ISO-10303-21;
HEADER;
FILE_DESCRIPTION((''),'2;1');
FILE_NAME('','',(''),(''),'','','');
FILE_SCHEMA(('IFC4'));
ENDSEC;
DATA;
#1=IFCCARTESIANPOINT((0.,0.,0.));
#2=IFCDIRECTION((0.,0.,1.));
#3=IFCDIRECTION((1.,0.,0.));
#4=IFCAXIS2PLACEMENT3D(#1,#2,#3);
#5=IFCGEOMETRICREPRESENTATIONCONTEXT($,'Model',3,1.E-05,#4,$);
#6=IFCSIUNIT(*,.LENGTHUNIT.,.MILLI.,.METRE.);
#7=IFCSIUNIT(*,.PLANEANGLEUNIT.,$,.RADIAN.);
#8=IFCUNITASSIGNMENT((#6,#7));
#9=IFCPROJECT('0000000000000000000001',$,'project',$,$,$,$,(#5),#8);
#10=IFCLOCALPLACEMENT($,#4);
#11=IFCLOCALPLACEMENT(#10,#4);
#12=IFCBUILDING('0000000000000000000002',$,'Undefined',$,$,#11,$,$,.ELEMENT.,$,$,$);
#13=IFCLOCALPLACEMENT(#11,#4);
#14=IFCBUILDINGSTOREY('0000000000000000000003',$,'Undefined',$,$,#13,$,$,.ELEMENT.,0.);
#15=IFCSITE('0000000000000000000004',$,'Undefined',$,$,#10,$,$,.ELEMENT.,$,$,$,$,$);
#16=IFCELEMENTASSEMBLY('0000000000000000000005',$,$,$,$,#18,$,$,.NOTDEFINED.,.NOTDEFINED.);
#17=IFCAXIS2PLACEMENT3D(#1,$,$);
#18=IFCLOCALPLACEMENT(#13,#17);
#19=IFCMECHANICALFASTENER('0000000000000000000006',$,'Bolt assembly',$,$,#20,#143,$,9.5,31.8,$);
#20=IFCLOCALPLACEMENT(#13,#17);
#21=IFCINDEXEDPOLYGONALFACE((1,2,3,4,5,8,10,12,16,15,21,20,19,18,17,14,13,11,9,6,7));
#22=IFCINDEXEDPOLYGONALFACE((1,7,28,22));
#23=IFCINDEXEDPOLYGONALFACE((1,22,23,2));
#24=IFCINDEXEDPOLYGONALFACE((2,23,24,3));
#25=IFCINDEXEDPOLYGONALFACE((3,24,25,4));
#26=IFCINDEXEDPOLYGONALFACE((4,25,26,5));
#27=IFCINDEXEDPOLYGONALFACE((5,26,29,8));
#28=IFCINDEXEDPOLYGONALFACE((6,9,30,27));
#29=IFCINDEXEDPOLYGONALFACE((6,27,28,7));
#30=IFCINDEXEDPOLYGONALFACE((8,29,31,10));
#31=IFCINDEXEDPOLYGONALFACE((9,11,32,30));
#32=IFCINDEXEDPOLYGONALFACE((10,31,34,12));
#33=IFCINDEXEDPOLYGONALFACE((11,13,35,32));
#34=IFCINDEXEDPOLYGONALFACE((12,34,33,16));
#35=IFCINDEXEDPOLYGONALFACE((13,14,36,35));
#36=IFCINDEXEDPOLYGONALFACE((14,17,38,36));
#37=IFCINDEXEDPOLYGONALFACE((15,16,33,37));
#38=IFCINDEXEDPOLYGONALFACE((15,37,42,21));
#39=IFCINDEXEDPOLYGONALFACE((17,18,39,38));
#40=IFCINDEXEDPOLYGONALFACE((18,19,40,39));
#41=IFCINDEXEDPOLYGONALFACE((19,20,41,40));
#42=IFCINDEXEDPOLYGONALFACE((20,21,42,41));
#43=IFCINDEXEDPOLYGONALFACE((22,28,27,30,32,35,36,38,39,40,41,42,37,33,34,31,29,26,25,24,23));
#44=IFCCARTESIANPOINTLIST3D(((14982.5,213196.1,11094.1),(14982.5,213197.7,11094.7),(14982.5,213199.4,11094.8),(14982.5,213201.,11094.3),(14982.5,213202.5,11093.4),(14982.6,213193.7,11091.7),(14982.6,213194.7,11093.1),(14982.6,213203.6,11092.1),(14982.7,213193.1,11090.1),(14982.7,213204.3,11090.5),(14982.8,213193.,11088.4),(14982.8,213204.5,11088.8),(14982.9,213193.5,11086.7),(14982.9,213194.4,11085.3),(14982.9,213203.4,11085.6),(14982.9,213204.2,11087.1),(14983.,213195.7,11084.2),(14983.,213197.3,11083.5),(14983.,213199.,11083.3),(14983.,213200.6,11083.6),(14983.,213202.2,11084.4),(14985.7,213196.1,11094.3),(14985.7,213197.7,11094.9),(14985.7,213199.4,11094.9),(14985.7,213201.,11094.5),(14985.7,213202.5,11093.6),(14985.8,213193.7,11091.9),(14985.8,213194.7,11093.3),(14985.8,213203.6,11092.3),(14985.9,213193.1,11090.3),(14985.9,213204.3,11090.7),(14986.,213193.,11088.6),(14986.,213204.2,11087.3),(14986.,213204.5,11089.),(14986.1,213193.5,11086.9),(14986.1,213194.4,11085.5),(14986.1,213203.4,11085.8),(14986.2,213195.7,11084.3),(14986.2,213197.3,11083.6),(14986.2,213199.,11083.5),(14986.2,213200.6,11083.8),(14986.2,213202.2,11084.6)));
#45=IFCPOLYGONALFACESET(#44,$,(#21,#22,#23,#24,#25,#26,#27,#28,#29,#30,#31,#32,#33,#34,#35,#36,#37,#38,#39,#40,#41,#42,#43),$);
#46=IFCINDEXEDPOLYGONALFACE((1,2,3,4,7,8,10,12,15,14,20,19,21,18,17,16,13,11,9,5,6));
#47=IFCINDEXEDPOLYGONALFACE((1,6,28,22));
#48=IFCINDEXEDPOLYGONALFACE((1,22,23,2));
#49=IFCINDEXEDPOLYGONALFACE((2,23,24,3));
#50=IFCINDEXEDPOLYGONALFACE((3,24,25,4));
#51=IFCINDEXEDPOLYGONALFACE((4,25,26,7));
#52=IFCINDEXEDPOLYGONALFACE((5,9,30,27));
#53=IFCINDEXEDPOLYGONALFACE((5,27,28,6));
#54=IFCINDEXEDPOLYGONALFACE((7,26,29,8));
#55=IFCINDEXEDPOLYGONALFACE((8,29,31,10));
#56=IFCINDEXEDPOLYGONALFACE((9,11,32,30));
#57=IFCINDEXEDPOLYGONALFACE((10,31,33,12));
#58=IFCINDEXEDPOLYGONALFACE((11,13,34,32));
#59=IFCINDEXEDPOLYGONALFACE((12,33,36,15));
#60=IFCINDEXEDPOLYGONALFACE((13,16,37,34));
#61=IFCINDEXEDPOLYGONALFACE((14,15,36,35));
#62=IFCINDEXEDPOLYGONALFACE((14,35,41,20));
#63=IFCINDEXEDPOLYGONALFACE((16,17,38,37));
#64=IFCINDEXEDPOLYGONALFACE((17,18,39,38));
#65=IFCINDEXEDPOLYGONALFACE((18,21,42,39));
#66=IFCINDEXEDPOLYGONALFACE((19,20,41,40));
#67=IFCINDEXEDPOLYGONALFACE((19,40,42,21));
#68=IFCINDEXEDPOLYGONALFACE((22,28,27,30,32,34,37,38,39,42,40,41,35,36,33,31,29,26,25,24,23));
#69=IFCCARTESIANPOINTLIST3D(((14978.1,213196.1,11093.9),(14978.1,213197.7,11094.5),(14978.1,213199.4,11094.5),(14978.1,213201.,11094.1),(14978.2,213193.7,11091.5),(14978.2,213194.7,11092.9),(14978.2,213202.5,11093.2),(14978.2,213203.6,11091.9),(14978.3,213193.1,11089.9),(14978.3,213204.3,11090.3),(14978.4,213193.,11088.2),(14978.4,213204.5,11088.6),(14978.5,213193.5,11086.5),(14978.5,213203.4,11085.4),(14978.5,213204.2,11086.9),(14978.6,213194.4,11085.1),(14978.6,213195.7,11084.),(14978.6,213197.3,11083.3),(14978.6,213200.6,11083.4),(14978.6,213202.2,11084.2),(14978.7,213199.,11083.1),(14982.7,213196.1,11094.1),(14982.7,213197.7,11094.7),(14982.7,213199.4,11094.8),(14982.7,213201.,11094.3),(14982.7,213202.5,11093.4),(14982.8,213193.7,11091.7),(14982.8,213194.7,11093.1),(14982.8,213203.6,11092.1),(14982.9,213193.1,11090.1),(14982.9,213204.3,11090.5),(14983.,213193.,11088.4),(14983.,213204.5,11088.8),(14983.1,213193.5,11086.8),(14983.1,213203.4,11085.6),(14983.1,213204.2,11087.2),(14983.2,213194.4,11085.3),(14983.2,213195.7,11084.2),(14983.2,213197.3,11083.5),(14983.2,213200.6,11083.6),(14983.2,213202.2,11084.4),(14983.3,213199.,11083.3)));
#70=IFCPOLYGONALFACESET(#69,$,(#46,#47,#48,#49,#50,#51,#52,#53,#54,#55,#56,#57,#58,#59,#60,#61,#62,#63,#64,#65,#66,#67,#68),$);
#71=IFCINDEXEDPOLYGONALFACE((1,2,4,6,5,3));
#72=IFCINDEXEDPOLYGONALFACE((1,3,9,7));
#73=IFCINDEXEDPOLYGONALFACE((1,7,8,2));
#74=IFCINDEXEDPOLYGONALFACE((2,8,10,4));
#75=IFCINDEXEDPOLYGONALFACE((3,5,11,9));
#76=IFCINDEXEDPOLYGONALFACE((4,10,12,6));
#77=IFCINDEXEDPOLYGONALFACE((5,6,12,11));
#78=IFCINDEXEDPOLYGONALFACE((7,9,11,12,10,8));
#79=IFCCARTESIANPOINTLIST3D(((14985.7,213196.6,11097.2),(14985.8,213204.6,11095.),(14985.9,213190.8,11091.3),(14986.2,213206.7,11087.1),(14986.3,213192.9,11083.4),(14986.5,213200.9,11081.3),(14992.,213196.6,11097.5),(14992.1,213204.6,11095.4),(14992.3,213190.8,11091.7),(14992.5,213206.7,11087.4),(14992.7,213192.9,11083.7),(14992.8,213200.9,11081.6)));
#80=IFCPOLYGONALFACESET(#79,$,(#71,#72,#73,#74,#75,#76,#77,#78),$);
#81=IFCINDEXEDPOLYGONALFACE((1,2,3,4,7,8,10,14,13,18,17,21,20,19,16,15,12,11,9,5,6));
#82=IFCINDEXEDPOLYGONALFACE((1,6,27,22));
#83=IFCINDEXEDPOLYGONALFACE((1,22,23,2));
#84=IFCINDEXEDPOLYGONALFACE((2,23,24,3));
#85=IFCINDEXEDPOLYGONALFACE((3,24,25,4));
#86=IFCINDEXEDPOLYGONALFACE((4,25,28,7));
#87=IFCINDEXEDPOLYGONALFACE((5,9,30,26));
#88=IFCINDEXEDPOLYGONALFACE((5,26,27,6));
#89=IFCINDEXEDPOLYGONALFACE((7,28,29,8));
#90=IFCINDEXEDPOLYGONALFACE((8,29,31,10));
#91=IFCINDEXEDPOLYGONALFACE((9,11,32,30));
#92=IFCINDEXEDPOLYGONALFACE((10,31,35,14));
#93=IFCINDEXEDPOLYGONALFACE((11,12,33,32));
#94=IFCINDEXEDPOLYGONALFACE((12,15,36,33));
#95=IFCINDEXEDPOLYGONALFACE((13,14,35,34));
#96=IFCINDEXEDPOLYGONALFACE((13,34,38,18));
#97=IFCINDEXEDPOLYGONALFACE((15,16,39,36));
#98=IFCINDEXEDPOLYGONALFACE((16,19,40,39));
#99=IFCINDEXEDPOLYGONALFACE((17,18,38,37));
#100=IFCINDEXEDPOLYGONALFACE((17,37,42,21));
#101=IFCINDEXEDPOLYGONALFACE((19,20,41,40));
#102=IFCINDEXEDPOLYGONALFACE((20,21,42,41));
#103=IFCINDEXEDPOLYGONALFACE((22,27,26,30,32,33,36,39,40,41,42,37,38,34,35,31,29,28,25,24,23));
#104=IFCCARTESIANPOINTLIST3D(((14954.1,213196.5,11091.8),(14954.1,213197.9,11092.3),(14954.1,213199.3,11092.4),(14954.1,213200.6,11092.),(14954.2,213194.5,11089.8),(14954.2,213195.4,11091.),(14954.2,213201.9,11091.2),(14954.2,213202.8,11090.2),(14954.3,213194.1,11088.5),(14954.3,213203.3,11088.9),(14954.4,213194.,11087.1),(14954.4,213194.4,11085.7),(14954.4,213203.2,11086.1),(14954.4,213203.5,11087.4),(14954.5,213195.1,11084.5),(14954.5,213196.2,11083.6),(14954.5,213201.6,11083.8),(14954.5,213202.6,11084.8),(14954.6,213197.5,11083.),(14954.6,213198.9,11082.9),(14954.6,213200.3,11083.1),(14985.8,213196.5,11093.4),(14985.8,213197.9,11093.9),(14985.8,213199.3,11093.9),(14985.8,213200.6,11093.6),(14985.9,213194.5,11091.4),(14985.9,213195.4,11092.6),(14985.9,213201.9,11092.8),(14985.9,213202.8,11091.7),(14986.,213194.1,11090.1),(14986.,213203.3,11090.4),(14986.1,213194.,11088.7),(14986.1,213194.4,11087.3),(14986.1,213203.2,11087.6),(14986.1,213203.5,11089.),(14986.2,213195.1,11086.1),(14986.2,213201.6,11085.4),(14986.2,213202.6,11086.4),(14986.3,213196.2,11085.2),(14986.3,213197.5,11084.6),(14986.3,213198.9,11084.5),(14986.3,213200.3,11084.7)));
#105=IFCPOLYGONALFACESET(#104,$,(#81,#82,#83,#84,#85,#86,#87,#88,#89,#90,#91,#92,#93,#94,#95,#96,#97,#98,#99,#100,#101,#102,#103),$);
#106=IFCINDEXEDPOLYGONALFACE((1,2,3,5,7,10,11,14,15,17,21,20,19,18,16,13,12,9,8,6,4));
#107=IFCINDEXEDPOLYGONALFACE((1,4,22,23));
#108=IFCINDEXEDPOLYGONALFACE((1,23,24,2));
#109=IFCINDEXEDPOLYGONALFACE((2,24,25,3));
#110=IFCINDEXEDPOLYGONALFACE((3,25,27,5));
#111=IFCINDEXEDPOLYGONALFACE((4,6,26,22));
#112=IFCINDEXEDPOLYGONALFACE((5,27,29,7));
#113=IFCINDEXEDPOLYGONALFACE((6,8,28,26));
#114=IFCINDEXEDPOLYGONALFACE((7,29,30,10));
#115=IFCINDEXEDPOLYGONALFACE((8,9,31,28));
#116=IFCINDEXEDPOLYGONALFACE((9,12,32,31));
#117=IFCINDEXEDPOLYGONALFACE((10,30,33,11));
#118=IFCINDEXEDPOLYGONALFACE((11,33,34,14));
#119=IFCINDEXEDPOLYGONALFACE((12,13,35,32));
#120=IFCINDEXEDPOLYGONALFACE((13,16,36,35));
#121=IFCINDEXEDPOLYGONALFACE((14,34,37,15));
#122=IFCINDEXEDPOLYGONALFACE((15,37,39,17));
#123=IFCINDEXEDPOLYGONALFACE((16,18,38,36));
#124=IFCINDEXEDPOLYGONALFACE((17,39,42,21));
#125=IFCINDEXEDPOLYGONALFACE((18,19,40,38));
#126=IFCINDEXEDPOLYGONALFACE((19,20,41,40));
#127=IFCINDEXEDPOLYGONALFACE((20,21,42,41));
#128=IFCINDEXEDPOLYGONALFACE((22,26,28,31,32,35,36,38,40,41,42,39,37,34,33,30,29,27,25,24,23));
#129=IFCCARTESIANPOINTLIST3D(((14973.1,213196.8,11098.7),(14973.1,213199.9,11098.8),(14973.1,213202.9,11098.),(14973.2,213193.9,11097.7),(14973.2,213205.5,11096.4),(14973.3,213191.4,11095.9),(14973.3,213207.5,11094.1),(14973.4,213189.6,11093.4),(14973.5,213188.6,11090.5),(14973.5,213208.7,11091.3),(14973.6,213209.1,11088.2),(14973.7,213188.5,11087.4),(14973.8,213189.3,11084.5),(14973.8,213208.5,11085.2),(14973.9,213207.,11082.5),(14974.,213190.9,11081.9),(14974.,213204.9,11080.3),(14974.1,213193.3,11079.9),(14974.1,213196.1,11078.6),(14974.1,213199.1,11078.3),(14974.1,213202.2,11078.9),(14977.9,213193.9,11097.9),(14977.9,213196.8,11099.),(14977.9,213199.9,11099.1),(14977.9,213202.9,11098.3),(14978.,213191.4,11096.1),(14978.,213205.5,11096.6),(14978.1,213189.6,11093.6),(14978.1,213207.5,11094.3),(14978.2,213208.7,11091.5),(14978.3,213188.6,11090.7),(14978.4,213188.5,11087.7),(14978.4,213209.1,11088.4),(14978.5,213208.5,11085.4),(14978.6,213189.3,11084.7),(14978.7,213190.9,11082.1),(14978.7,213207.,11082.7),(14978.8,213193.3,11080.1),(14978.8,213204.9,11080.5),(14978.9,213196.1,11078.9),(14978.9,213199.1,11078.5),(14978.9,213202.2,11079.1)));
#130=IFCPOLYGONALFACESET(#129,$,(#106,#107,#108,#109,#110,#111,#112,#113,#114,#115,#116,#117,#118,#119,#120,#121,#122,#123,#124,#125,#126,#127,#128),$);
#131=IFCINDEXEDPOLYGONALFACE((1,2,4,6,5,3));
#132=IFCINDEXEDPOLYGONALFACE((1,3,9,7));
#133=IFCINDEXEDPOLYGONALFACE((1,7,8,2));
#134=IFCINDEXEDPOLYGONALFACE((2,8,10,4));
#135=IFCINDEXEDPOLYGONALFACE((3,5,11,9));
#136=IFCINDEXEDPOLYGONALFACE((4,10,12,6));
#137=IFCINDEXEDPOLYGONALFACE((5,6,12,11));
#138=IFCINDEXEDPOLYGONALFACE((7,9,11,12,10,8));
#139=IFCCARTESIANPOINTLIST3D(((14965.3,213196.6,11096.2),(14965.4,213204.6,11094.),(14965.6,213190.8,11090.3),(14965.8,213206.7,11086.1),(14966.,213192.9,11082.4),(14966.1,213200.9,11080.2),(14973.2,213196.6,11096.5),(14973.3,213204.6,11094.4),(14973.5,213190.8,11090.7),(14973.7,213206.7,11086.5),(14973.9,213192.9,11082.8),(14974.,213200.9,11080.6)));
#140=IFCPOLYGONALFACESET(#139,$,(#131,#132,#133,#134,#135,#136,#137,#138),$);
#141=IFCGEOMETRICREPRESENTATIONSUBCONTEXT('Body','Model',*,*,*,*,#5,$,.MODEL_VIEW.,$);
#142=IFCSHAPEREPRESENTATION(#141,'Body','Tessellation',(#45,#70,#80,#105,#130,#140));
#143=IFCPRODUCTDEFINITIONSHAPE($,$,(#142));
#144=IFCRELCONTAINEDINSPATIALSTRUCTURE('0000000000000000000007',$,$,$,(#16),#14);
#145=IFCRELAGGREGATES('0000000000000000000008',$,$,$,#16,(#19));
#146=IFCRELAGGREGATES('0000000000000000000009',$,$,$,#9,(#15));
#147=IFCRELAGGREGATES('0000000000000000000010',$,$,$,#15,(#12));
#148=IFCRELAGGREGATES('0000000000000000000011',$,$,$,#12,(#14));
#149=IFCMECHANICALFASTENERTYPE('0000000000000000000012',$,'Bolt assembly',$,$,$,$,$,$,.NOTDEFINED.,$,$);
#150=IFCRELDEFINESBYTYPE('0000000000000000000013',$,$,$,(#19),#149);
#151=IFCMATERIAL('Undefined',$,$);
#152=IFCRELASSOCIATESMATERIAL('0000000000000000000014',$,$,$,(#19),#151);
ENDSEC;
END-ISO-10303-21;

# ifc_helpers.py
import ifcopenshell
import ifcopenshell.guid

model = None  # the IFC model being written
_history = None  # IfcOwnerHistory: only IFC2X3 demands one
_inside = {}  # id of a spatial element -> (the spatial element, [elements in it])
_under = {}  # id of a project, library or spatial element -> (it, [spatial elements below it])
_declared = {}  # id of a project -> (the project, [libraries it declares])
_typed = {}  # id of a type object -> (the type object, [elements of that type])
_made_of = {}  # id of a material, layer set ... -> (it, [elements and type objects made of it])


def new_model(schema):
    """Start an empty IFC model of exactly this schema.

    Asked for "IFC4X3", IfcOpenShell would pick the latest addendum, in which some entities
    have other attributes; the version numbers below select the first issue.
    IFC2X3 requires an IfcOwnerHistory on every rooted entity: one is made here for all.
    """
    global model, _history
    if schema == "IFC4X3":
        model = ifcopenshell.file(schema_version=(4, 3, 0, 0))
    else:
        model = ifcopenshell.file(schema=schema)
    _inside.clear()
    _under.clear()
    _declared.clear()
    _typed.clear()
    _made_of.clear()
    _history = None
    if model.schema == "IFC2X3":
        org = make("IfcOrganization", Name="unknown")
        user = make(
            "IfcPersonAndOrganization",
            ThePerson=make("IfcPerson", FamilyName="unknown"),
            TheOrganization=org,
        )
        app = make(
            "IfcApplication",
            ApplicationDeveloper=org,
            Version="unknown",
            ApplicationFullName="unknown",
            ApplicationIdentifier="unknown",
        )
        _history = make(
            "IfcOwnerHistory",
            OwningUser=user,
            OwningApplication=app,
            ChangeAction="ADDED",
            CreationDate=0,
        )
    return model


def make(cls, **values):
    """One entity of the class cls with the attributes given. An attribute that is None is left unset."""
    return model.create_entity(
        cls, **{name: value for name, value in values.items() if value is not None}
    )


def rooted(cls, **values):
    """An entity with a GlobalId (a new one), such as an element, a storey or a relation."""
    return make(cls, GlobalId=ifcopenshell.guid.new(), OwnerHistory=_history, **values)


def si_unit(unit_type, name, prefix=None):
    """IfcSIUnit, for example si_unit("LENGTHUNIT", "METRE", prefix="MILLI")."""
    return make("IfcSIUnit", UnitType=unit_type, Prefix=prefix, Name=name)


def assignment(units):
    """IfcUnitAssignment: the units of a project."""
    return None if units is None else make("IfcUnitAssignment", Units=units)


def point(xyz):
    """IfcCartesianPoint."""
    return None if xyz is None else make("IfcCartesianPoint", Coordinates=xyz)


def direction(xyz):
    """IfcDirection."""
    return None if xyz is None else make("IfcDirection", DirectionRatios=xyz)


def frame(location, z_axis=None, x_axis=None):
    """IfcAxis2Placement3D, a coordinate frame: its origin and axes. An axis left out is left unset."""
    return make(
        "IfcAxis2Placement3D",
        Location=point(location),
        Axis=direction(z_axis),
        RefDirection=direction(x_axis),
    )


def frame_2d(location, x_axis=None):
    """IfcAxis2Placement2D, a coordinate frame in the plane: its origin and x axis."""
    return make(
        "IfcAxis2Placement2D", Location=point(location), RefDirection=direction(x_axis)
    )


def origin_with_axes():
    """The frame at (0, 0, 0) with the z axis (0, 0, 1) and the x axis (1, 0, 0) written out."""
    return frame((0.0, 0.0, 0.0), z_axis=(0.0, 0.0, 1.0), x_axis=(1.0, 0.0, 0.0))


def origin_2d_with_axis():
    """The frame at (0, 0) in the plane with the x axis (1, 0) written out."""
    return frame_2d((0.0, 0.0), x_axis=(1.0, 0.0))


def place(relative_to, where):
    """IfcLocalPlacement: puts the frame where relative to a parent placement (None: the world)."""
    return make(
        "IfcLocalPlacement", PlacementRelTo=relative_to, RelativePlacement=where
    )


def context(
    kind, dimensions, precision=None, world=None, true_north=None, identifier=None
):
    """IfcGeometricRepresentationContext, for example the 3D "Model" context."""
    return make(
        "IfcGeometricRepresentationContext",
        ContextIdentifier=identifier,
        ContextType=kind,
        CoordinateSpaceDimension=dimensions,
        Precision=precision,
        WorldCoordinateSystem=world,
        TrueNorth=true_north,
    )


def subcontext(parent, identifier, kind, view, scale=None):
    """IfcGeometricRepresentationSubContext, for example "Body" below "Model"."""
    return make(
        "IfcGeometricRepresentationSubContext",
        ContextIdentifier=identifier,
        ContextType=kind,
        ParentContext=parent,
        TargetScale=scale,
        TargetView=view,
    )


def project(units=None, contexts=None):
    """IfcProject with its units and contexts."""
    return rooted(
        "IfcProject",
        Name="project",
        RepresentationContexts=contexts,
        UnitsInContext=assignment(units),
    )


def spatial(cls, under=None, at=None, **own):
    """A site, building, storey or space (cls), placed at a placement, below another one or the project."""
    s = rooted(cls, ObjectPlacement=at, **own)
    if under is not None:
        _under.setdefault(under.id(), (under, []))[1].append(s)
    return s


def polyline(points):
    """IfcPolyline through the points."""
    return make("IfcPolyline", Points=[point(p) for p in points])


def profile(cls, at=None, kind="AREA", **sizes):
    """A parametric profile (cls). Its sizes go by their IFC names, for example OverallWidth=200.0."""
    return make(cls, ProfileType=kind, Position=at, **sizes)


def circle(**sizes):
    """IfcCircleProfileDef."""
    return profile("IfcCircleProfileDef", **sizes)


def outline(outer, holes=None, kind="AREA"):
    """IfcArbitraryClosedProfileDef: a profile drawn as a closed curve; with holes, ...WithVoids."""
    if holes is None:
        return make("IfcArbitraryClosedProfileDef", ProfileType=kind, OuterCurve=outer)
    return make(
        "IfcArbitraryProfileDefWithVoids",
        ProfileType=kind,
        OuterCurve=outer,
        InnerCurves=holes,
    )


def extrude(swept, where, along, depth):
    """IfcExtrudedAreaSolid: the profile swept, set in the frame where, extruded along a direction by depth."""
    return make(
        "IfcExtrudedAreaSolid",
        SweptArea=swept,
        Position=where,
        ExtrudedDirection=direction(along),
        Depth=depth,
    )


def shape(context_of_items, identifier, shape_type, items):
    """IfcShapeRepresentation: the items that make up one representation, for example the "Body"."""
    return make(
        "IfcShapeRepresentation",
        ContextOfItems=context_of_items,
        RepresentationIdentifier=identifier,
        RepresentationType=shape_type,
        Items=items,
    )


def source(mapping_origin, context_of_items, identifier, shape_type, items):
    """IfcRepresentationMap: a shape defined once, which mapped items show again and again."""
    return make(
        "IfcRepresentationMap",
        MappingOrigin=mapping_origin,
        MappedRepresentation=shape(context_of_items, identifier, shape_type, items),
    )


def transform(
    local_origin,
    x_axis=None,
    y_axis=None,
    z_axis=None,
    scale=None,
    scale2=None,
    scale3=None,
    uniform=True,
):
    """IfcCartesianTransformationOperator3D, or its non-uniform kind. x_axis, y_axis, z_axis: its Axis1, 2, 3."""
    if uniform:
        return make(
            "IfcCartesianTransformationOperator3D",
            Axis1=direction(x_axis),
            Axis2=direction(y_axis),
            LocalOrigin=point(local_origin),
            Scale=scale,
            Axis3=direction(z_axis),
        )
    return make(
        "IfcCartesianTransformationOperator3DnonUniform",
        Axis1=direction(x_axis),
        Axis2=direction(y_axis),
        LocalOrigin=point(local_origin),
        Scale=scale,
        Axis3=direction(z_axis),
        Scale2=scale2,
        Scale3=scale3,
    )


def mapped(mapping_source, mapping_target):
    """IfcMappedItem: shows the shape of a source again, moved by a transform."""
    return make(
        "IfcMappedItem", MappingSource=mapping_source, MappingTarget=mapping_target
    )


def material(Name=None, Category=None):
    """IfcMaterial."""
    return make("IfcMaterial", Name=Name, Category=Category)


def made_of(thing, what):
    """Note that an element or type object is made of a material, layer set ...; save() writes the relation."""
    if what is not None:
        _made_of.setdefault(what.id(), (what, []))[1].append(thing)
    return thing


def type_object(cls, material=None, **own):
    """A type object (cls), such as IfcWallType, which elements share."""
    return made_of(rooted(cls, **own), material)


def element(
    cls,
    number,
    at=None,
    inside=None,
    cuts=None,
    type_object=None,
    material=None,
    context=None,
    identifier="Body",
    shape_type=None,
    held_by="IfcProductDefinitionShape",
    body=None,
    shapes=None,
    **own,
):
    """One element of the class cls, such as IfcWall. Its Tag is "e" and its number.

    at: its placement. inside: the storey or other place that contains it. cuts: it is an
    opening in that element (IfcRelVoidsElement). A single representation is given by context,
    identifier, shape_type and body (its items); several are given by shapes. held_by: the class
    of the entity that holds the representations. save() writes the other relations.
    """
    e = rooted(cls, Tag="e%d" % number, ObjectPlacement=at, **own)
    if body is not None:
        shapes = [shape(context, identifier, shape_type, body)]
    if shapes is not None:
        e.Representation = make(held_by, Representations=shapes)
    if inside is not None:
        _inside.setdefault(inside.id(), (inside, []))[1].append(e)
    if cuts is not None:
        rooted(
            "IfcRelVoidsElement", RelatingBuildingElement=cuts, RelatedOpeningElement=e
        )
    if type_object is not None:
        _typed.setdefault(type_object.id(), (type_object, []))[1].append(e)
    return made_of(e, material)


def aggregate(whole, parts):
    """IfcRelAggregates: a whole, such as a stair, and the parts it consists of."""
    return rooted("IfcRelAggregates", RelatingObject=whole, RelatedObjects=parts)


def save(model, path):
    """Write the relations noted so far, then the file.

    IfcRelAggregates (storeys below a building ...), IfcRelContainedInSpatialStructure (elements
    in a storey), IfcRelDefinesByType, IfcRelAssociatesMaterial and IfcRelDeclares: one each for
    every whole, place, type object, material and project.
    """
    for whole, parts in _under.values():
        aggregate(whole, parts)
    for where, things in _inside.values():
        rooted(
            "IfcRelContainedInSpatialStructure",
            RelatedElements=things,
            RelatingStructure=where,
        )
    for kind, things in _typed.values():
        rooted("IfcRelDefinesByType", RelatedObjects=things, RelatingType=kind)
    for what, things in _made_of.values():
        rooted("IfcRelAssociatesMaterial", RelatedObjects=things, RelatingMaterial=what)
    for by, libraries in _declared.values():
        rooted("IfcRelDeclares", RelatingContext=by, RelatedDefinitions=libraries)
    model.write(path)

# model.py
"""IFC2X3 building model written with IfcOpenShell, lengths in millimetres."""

from ifc_helpers import new_model, si_unit, frame, origin_with_axes, origin_2d_with_axis, place, context, subcontext, project, spatial, polyline, circle, outline, extrude, source, transform, mapped, material, type_object, element, aggregate, save


model = new_model("IFC2X3")

# Units and contexts
model_context = context("Model", 3, precision=1e-05, world=origin_with_axes())
body_context = subcontext(model_context, "Body", "Model", "MODEL_VIEW")
ifc_project = project(units=[si_unit("LENGTHUNIT", "METRE", prefix="MILLI"), si_unit("PLANEANGLEUNIT", "RADIAN")], contexts=[model_context])

# Site, building, storey
site_placement = place(None, origin_with_axes())
site = spatial("IfcSite", under=ifc_project, at=site_placement, Name="Undefined", CompositionType="ELEMENT")
building_placement = place(site_placement, origin_with_axes())
building = spatial("IfcBuilding", under=site, at=building_placement, Name="Undefined", CompositionType="ELEMENT")
storey_placement = place(building_placement, origin_with_axes())
storey = spatial("IfcBuildingStorey", under=building, at=storey_placement, Name="Undefined", CompositionType="ELEMENT", Elevation=0.0)

# Element assembly
assembly_1_placement = place(storey_placement, origin_with_axes())
assembly_1 = element("IfcElementAssembly", 1, at=assembly_1_placement, inside=storey, AssemblyPlace="NOTDEFINED", PredefinedType="NOTDEFINED")

# Mechanical fastener
ifc_material_1 = material(Name="Undefined")
mechanical_fastener_type = type_object("IfcMechanicalFastenerType", Name="Bolt assembly")
shared_shape_1 = source(origin_with_axes(), body_context, "Body", "SweptSolid", [
    extrude(circle(Radius=5.8, at=origin_2d_with_axis()), frame((0.0, -7.6, 0.0), z_axis=(0.0, 1.0, 0.0), x_axis=(1.0, 0.0, 0.0)), (0.0, 0.0, 1.0), 3.2),
    extrude(circle(Radius=5.8, at=origin_2d_with_axis()), frame((0.0, -4.6, 0.0), z_axis=(0.0, 1.0, 0.0), x_axis=(1.0, 0.0, 0.0)), (0.0, 0.0, 1.0), 4.6),
    extrude(outline(polyline([(7.1, -4.1), (7.1, 4.1), (0.0, 8.2), (-7.1, 4.1), (-7.1, -4.1), (0.0, -8.2), (7.1, -4.1)])), frame((0.0, -14.0, 0.0), z_axis=(0.0, 1.0, 0.0), x_axis=(1.0, 0.0, 0.0)), (0.0, 0.0, 1.0), 6.3),
    extrude(circle(Radius=4.8, at=origin_2d_with_axis()), frame((0.0, -7.7, 0.0), z_axis=(0.0, 1.0, 0.0), x_axis=(1.0, 0.0, 0.0)), (0.0, 0.0, 1.0), 31.8),
    extrude(circle(Radius=10.3, at=origin_2d_with_axis()), frame((0.0, 0.0, 0.0), z_axis=(0.0, 1.0, 0.0), x_axis=(1.0, 0.0, 0.0)), (0.0, 0.0, 1.0), 4.8),
    extrude(outline(polyline([(7.1, -4.1), (7.1, 4.1), (0.0, 8.2), (-7.1, 4.1), (-7.1, -4.1), (0.0, -8.2), (7.1, -4.1)])), frame((0.0, 4.8, 0.0), z_axis=(0.0, 1.0, 0.0), x_axis=(1.0, 0.0, 0.0)), (0.0, 0.0, 1.0), 7.9),
])
mechanical_fastener_1_placement = place(assembly_1_placement, frame((14978.4, 213198.7, 11088.8), z_axis=(0.035281, -0.707107, -0.706226), x_axis=(-0.035281, -0.707107, 0.706226)))
mechanical_fastener_1 = element("IfcMechanicalFastener", 2, at=mechanical_fastener_1_placement, type_object=mechanical_fastener_type, material=ifc_material_1, Name="Bolt assembly", NominalDiameter=9.5, NominalLength=31.8, context=body_context, shape_type="MappedRepresentation", body=[
    mapped(shared_shape_1, transform((0.0, 0.0, 0.0))),
])
aggregate(assembly_1, [mechanical_fastener_1])

save(model, "model.ifc")
